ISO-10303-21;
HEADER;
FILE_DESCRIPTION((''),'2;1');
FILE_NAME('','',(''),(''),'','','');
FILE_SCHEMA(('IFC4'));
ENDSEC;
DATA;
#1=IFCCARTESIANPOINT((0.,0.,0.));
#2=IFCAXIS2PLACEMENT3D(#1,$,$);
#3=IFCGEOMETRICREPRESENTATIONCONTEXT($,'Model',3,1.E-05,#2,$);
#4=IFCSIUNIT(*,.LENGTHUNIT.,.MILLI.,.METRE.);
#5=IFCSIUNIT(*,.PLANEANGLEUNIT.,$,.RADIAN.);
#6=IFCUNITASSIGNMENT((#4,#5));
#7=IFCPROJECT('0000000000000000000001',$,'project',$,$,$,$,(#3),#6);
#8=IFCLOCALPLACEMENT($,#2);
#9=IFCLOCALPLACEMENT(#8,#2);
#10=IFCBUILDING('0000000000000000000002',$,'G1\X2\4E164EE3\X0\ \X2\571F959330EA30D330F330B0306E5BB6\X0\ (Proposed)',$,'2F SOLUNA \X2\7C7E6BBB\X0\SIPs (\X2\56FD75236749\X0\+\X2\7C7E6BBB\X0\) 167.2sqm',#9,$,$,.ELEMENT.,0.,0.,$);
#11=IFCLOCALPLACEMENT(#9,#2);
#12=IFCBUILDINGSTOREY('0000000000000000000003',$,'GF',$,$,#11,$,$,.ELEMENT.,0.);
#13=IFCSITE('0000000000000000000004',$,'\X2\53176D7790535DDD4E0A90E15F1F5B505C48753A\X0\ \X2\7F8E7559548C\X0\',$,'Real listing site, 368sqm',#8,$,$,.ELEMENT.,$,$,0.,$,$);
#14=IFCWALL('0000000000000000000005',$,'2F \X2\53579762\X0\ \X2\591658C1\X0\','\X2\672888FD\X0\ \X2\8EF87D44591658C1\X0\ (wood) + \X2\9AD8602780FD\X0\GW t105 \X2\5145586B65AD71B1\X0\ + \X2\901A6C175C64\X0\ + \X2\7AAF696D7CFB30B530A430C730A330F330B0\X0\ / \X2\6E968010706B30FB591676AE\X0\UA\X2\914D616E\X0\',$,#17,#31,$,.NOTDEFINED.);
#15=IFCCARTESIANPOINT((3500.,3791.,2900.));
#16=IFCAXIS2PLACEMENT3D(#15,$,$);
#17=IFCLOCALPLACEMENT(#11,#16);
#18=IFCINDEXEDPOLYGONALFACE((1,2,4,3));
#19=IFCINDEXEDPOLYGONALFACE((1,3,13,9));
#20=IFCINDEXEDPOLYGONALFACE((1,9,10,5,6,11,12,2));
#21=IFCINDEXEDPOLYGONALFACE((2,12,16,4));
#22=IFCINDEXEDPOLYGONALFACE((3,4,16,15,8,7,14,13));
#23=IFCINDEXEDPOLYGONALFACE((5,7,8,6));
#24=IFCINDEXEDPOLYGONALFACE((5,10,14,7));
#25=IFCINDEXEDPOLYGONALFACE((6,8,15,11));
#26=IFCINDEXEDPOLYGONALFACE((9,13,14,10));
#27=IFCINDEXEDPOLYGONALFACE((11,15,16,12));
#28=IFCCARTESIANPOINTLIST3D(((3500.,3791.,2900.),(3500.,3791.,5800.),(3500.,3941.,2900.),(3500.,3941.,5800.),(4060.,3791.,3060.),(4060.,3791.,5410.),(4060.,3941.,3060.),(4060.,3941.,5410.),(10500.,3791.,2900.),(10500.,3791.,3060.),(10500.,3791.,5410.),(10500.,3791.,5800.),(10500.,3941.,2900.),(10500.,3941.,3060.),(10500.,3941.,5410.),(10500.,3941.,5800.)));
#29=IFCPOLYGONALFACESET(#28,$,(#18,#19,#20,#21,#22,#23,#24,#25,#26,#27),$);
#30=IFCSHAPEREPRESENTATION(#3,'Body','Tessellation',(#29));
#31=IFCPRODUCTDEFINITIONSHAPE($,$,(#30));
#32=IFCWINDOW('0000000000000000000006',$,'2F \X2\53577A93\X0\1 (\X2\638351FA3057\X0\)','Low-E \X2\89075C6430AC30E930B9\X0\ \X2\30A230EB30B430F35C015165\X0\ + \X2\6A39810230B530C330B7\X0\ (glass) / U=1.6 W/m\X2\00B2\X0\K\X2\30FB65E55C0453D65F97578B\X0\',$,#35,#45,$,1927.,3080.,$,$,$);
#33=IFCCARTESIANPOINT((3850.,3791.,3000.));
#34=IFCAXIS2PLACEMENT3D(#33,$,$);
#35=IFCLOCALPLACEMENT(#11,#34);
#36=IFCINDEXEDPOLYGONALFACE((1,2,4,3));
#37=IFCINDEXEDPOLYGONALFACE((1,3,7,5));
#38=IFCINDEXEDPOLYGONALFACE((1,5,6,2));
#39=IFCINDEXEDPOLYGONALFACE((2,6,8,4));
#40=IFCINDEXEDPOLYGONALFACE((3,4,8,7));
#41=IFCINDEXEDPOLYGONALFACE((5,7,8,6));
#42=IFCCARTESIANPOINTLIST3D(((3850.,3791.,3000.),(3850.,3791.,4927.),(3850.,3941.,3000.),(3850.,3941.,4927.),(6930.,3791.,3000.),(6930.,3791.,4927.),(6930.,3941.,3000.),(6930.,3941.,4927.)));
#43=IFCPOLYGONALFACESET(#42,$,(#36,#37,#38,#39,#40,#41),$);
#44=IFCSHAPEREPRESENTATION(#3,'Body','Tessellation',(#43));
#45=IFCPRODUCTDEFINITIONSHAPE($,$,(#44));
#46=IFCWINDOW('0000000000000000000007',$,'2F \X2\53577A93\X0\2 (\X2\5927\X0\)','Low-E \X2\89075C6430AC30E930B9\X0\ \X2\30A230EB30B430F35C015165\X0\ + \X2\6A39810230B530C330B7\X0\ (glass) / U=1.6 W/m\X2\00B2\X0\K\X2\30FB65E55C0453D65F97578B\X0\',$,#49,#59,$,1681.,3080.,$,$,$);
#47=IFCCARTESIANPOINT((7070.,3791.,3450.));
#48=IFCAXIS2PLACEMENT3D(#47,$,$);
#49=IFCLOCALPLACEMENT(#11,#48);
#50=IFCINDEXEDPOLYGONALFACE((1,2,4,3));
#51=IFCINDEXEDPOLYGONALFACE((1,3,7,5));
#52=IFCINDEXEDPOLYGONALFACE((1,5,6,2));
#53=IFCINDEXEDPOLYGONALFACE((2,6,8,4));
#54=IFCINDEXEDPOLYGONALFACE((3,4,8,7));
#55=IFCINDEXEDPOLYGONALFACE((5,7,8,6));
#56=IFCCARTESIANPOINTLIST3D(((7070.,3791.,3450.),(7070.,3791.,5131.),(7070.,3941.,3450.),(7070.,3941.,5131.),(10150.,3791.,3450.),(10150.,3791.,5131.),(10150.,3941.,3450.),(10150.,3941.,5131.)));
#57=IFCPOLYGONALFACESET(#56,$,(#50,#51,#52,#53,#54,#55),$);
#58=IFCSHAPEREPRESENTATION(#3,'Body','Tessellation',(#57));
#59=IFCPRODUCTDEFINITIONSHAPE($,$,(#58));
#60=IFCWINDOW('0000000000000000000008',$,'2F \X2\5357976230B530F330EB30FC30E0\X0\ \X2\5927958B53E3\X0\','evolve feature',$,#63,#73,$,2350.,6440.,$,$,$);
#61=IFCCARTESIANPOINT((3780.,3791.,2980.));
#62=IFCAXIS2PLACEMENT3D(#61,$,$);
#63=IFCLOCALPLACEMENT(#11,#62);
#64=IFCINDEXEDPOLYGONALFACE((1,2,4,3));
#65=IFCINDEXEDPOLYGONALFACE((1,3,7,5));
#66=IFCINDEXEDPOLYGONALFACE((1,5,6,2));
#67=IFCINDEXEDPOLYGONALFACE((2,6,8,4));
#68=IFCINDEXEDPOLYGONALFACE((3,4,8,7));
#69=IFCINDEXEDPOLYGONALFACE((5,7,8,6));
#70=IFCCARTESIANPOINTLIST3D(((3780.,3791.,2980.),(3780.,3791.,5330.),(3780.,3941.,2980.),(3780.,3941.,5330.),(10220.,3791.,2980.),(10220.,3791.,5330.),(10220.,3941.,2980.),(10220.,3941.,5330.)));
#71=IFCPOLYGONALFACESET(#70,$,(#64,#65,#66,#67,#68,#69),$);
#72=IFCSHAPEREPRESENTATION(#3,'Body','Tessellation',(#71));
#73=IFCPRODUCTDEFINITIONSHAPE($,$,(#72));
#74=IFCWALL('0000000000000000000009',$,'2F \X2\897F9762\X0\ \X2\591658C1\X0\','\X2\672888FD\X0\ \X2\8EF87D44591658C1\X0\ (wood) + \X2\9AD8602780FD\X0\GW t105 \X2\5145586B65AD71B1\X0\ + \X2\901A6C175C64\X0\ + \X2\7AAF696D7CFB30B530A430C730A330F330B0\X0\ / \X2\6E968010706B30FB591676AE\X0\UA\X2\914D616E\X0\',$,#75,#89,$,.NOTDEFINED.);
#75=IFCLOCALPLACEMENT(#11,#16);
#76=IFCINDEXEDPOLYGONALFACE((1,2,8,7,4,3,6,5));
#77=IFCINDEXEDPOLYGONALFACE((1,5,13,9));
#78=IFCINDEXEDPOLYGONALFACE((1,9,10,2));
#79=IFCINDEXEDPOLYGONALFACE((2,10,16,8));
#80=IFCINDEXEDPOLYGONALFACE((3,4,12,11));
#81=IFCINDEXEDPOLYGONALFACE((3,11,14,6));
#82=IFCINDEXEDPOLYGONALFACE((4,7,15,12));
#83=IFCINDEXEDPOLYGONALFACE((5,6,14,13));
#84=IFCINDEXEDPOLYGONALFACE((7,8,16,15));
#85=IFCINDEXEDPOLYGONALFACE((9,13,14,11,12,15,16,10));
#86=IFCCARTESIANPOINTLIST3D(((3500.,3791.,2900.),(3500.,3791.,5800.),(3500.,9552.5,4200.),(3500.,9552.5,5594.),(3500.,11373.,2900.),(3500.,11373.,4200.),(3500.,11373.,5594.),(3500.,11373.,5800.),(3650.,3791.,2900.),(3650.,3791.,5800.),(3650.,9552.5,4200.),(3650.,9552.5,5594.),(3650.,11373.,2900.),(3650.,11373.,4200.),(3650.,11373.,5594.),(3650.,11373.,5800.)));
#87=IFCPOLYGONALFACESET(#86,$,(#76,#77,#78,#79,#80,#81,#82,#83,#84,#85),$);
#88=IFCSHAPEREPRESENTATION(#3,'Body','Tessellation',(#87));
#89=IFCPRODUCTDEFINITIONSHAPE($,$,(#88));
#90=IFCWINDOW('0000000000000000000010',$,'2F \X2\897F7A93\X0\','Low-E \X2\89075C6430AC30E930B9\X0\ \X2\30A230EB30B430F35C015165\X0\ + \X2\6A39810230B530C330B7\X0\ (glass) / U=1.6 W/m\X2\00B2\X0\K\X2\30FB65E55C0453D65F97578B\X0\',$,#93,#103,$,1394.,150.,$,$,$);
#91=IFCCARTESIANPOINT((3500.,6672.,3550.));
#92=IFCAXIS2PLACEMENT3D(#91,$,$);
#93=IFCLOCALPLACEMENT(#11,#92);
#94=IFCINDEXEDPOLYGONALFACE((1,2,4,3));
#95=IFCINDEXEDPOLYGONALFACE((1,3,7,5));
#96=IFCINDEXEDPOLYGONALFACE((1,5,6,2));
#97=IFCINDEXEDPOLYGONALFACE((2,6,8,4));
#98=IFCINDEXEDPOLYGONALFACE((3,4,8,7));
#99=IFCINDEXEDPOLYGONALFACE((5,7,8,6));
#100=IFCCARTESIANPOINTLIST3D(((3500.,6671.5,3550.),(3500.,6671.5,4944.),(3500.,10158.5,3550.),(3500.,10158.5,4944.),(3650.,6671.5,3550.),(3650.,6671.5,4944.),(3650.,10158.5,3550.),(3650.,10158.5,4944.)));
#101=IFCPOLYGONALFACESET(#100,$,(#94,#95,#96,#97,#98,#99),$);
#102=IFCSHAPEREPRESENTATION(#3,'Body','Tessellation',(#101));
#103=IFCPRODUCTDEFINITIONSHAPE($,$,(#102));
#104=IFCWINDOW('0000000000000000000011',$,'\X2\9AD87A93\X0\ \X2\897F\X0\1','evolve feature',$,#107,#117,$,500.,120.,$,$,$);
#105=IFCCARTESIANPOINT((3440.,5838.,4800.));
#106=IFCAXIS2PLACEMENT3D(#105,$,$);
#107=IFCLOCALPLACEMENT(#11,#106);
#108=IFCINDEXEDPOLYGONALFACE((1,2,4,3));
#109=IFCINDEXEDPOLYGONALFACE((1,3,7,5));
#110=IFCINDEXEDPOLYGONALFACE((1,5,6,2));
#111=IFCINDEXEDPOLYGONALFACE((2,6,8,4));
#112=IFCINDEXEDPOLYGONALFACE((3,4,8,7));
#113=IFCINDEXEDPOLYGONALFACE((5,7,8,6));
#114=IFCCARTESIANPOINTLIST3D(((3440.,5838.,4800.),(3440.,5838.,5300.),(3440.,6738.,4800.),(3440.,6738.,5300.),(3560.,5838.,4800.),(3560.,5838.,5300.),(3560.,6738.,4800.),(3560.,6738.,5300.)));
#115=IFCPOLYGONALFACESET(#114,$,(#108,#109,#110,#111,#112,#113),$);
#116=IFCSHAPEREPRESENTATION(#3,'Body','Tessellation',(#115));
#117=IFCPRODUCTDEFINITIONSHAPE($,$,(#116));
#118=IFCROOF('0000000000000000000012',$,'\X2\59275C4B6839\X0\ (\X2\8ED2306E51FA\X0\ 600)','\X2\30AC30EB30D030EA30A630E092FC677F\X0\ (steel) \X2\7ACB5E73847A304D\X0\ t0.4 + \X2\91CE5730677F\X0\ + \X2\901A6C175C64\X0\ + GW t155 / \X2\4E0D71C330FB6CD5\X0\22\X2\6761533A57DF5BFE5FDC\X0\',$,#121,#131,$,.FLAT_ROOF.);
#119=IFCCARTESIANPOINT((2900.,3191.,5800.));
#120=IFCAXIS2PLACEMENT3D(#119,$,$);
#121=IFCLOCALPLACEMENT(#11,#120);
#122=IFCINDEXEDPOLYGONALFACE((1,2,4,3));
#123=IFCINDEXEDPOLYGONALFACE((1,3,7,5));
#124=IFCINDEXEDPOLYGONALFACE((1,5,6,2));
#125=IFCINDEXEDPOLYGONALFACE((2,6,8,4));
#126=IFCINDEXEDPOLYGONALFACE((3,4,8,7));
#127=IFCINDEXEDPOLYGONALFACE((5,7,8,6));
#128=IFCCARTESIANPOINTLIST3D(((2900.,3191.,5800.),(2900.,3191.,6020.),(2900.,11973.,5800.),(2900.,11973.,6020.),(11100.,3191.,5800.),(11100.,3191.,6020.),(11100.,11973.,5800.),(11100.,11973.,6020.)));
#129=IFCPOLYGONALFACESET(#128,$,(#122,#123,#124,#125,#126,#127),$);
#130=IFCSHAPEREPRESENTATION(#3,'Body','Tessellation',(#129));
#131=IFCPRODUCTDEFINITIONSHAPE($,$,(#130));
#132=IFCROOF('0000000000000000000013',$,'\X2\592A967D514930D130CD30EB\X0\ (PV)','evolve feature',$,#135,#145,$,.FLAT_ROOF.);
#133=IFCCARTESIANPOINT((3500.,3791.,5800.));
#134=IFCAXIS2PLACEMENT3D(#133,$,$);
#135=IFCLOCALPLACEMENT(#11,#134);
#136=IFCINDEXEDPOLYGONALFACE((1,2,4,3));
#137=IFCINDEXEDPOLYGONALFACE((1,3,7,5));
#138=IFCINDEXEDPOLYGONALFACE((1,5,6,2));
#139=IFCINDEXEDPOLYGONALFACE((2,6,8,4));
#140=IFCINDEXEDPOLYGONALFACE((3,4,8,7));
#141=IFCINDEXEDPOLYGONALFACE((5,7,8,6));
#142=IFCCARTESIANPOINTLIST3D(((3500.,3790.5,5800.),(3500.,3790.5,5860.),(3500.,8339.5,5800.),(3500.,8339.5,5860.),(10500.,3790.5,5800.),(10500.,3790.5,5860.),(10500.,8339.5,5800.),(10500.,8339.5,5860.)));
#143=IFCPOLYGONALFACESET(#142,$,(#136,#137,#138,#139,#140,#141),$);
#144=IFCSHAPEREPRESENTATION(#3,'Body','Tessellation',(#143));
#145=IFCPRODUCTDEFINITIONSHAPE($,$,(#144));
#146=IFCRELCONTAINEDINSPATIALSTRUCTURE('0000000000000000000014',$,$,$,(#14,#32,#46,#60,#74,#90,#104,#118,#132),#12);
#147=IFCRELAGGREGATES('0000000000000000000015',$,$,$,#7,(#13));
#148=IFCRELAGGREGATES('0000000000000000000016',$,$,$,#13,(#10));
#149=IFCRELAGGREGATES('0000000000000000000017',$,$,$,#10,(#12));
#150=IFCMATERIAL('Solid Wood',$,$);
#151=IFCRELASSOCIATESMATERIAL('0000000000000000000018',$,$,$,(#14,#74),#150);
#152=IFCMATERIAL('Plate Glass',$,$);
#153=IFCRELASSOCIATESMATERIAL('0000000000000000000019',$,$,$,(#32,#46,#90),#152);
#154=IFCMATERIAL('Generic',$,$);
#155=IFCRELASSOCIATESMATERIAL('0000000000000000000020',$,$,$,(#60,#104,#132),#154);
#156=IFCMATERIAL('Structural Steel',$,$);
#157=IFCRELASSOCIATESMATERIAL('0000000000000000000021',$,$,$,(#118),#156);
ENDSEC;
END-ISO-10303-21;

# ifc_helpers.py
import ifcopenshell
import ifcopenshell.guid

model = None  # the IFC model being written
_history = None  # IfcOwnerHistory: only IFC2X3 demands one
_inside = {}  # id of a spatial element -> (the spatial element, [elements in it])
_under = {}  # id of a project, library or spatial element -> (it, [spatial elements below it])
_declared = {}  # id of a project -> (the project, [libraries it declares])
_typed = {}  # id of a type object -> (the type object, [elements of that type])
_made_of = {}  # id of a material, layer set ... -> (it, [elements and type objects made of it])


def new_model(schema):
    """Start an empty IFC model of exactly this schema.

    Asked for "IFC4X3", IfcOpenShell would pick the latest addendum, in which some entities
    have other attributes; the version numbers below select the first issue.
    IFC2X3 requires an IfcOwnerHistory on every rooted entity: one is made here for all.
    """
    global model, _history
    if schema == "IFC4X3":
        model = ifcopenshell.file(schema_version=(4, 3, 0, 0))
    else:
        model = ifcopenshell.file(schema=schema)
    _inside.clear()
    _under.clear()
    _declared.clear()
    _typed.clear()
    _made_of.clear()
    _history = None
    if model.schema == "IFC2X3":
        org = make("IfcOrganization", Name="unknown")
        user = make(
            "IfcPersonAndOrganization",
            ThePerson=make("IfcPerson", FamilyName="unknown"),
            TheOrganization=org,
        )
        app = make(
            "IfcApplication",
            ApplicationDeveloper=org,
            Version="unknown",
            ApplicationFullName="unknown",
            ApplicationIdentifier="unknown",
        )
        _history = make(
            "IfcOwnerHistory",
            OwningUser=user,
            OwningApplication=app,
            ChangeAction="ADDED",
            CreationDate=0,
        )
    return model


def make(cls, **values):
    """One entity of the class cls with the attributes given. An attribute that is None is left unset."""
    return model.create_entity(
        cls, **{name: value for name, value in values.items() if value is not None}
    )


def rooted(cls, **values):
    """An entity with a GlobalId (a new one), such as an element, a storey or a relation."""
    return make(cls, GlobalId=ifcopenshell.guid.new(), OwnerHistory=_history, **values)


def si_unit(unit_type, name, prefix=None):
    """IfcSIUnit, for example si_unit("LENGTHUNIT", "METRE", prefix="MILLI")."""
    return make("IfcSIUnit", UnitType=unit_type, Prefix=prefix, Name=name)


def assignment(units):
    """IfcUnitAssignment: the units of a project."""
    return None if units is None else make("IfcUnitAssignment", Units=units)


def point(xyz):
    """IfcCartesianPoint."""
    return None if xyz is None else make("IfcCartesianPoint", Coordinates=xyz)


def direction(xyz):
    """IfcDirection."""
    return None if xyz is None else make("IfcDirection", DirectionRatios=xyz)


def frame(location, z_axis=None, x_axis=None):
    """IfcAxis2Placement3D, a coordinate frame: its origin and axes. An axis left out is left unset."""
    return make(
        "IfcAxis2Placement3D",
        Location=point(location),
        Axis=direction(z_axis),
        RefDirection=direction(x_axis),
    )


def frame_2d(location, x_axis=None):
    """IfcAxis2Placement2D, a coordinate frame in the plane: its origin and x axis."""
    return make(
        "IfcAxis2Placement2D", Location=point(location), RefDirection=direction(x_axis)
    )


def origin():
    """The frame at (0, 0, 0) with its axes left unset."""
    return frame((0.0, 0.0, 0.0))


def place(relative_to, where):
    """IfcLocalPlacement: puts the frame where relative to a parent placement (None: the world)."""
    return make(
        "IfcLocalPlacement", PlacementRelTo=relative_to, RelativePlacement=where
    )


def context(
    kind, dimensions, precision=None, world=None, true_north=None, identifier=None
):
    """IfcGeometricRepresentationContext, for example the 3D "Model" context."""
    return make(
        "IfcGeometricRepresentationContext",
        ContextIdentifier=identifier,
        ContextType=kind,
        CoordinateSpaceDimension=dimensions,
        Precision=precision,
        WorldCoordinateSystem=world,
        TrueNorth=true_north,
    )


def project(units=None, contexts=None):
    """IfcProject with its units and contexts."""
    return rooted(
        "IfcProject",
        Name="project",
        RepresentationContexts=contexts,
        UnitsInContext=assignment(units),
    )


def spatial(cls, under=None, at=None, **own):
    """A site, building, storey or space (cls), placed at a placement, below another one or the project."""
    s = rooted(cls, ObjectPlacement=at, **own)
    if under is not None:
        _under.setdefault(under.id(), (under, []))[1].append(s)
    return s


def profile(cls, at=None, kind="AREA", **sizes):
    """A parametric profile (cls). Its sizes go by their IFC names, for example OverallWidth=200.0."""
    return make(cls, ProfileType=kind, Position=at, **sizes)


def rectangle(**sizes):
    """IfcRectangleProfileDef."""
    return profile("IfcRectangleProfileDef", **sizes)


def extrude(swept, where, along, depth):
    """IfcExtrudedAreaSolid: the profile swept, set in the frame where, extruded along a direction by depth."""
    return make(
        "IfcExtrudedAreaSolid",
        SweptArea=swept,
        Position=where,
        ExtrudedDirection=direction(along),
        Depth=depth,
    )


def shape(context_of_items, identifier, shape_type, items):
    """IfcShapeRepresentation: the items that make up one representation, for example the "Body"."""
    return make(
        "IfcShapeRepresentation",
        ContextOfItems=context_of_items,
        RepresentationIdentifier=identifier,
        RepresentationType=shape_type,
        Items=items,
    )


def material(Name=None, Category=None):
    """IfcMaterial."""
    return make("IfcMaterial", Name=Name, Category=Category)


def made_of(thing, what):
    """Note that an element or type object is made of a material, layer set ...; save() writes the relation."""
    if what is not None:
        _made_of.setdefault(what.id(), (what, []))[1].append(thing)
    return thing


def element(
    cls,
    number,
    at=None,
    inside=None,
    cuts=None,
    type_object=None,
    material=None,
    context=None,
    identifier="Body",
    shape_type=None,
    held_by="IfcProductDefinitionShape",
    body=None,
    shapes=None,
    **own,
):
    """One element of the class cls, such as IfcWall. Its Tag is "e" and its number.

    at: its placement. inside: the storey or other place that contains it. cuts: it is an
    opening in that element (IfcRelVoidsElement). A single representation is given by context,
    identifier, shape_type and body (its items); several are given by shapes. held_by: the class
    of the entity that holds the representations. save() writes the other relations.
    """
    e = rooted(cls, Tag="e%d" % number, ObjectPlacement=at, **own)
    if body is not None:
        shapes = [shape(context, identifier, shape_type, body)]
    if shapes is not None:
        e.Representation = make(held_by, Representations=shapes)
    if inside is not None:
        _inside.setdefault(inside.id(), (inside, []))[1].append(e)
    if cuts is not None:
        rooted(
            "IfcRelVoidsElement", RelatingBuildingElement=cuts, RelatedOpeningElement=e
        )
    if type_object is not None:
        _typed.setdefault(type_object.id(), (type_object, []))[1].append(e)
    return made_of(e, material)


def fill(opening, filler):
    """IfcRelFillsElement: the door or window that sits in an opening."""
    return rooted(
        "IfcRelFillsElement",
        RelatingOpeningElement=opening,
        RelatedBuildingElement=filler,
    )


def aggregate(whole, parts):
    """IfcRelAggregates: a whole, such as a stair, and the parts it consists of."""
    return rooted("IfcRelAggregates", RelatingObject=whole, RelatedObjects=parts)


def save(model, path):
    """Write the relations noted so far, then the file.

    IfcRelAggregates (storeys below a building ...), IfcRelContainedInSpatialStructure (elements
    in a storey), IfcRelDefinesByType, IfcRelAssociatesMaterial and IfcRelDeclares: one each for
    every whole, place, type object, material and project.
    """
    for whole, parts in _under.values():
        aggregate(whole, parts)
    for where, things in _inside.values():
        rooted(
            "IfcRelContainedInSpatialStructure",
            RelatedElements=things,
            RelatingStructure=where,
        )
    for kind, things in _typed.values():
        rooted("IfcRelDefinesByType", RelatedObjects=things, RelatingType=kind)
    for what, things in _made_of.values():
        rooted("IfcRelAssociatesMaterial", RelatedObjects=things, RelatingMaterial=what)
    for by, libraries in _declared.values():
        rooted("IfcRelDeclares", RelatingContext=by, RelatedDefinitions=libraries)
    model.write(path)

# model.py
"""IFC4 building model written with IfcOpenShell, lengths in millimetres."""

from ifc_helpers import new_model, si_unit, frame, frame_2d, origin, place, context, project, spatial, rectangle, extrude, material, element, fill, save


model = new_model("IFC4")

# Units and contexts
model_context = context("Model", 3, precision=1e-05, world=origin())
ifc_project = project(units=[si_unit("LENGTHUNIT", "METRE", prefix="MILLI"), si_unit("PLANEANGLEUNIT", "RADIAN")], contexts=[model_context])

# Site, building, storey
site_placement = place(None, origin())
site = spatial("IfcSite", under=ifc_project, at=site_placement, Name="北海道川上郡弟子屈町 美留和", ObjectType="Real listing site, 368sqm", CompositionType="ELEMENT", RefElevation=0.0)
building_placement = place(site_placement, origin())
building = spatial("IfcBuilding", under=site, at=building_placement, Name="G1世代 土間リビングの家 (Proposed)", ObjectType="2F SOLUNA 籾殻SIPs (国産杉+籾殻) 167.2sqm", CompositionType="ELEMENT", ElevationOfRefHeight=0.0, ElevationOfTerrain=0.0)
storey_placement = place(building_placement, origin())
storey = spatial("IfcBuildingStorey", under=building, at=storey_placement, Name="GF", CompositionType="ELEMENT", Elevation=0.0)

# Shared definitions
ifc_material_1 = material(Name="Solid Wood")
ifc_material_2 = material(Name="Generic")

# Shared definitions
ifc_material_3 = material(Name="Plate Glass")

# Walls, openings, windows
wall_1_placement = place(storey_placement, frame((3500.0, 3791.0, 2900.0)))
wall_1 = element("IfcWall", 1, at=wall_1_placement, inside=storey, material=ifc_material_1, Name="2F 南面 外壁", Description="木製 軸組外壁 (wood) + 高性能GW t105 充填断熱 + 通気層 + 窯業系サイディング / 準耐火・外皮UA配慮", PredefinedType="NOTDEFINED", context=model_context, shape_type="SweptSolid", body=[
    extrude(rectangle(XDim=7000.0, YDim=150.0, at=frame_2d((3500.0, 75.0))), frame((3500.0, 3791.0, 2900.0)), (0.0, 0.0, 1.0), 2900.0),
])
opening_1_placement = place(storey_placement, frame((3850.0, 3791.0, 3000.0)))
opening_1 = element("IfcOpeningElement", 2, at=opening_1_placement, cuts=wall_1, PredefinedType="NOTDEFINED", context=model_context, shape_type="SweptSolid", body=[
    extrude(rectangle(XDim=3080.0, YDim=150.0, at=frame_2d((1540.0, 75.0))), frame((3850.0, 3791.0, 3000.0)), (0.0, 0.0, 1.0), 1927.0),
])
opening_2_placement = place(storey_placement, frame((7070.0, 3791.0, 3450.0)))
opening_2 = element("IfcOpeningElement", 3, at=opening_2_placement, cuts=wall_1, PredefinedType="NOTDEFINED", context=model_context, shape_type="SweptSolid", body=[
    extrude(rectangle(XDim=3080.0, YDim=150.0, at=frame_2d((1540.0, 75.0))), frame((7070.0, 3791.0, 3450.0)), (0.0, 0.0, 1.0), 1681.0),
])
opening_3_placement = place(storey_placement, frame((3780.0, 3791.0, 2980.0)))
opening_3 = element("IfcOpeningElement", 4, at=opening_3_placement, cuts=wall_1, PredefinedType="NOTDEFINED", context=model_context, shape_type="SweptSolid", body=[
    extrude(rectangle(XDim=6440.0, YDim=150.0, at=frame_2d((3220.0, 75.0))), frame((3780.0, 3791.0, 2980.0)), (0.0, 0.0, 1.0), 2350.0),
])
window_1_placement = place(storey_placement, frame((3850.0, 3791.0, 3000.0)))
window_1 = element("IfcWindow", 5, at=window_1_placement, inside=storey, material=ifc_material_3, Name="2F 南窓1 (掃出し)", Description="Low-E 複層ガラス アルゴン封入 + 樹脂サッシ (glass) / U=1.6 W/m²K・日射取得型", OverallHeight=1927.0, OverallWidth=3080.0, context=model_context, shape_type="SweptSolid", body=[
    extrude(rectangle(XDim=3080.0, YDim=150.0, at=frame_2d((1540.0, 75.0))), frame((3850.0, 3791.0, 3000.0)), (0.0, 0.0, 1.0), 1927.0),
])
fill(opening_1, window_1)
window_2_placement = place(storey_placement, frame((7070.0, 3791.0, 3450.0)))
window_2 = element("IfcWindow", 6, at=window_2_placement, inside=storey, material=ifc_material_3, Name="2F 南窓2 (大)", Description="Low-E 複層ガラス アルゴン封入 + 樹脂サッシ (glass) / U=1.6 W/m²K・日射取得型", OverallHeight=1681.0, OverallWidth=3080.0, context=model_context, shape_type="SweptSolid", body=[
    extrude(rectangle(XDim=3080.0, YDim=150.0, at=frame_2d((1540.0, 75.0))), frame((7070.0, 3791.0, 3450.0)), (0.0, 0.0, 1.0), 1681.0),
])
fill(opening_2, window_2)
window_3_placement = place(storey_placement, frame((3780.0, 3791.0, 2980.0)))
window_3 = element("IfcWindow", 7, at=window_3_placement, inside=storey, material=ifc_material_2, Name="2F 南面サンルーム 大開口", Description="evolve feature", OverallHeight=2350.0, OverallWidth=6440.0, context=model_context, shape_type="SweptSolid", body=[
    extrude(rectangle(XDim=6440.0, YDim=150.0, at=frame_2d((3220.0, 75.0))), frame((3780.0, 3791.0, 2980.0)), (0.0, 0.0, 1.0), 2350.0),
])
fill(opening_3, window_3)
wall_2_placement = place(storey_placement, frame((3500.0, 3791.0, 2900.0)))
wall_2 = element("IfcWall", 8, at=wall_2_placement, inside=storey, material=ifc_material_1, Name="2F 西面 外壁", Description="木製 軸組外壁 (wood) + 高性能GW t105 充填断熱 + 通気層 + 窯業系サイディング / 準耐火・外皮UA配慮", PredefinedType="NOTDEFINED", context=model_context, shape_type="SweptSolid", body=[
    extrude(rectangle(XDim=150.0, YDim=7582.0, at=frame_2d((75.0, 3791.0))), frame((3500.0, 3791.0, 2900.0)), (0.0, 0.0, 1.0), 2900.0),
])
opening_4_placement = place(storey_placement, frame((3500.0, 6672.0, 3550.0)))
opening_4 = element("IfcOpeningElement", 9, at=opening_4_placement, cuts=wall_2, PredefinedType="NOTDEFINED", context=model_context, shape_type="SweptSolid", body=[
    extrude(rectangle(XDim=150.0, YDim=3487.0, at=frame_2d((75.0, 1743.0))), frame((3500.0, 6672.0, 3550.0)), (0.0, 0.0, 1.0), 1394.0),
])
opening_5_placement = place(storey_placement, frame((3440.0, 5838.0, 4800.0)))
opening_5 = element("IfcOpeningElement", 10, at=opening_5_placement, cuts=wall_2, PredefinedType="NOTDEFINED", context=model_context, shape_type="SweptSolid", body=[
    extrude(rectangle(XDim=120.0, YDim=900.0, at=frame_2d((60.0, 450.0))), frame((3440.0, 5838.0, 4800.0)), (0.0, 0.0, 1.0), 500.0),
])
window_4_placement = place(storey_placement, frame((3500.0, 6672.0, 3550.0)))
window_4 = element("IfcWindow", 11, at=window_4_placement, inside=storey, material=ifc_material_3, Name="2F 西窓", Description="Low-E 複層ガラス アルゴン封入 + 樹脂サッシ (glass) / U=1.6 W/m²K・日射取得型", OverallHeight=1394.0, OverallWidth=150.0, context=model_context, shape_type="SweptSolid", body=[
    extrude(rectangle(XDim=150.0, YDim=3487.0, at=frame_2d((75.0, 1743.0))), frame((3500.0, 6672.0, 3550.0)), (0.0, 0.0, 1.0), 1394.0),
])
fill(opening_4, window_4)
window_5_placement = place(storey_placement, frame((3440.0, 5838.0, 4800.0)))
window_5 = element("IfcWindow", 12, at=window_5_placement, inside=storey, material=ifc_material_2, Name="高窓 西1", Description="evolve feature", OverallHeight=500.0, OverallWidth=120.0, context=model_context, shape_type="SweptSolid", body=[
    extrude(rectangle(XDim=120.0, YDim=900.0, at=frame_2d((60.0, 450.0))), frame((3440.0, 5838.0, 4800.0)), (0.0, 0.0, 1.0), 500.0),
])
fill(opening_5, window_5)

# Roofs
ifc_material_4 = material(Name="Structural Steel")
roof_1_placement = place(storey_placement, frame((2900.0, 3191.0, 5800.0)))
element("IfcRoof", 13, at=roof_1_placement, inside=storey, material=ifc_material_4, Name="大屋根 (軒の出 600)", Description="ガルバリウム鋼板 (steel) 立平葺き t0.4 + 野地板 + 通気層 + GW t155 / 不燃・法22条区域対応", PredefinedType="FLAT_ROOF", context=model_context, shape_type="SweptSolid", body=[
    extrude(rectangle(XDim=8200.0, YDim=8782.0, at=frame_2d((4100.0, 4391.0))), frame((2900.0, 3191.0, 5800.0)), (0.0, 0.0, 1.0), 220.0),
])
roof_2_placement = place(storey_placement, frame((3500.0, 3791.0, 5800.0)))
element("IfcRoof", 14, at=roof_2_placement, inside=storey, material=ifc_material_2, Name="太陽光パネル (PV)", Description="evolve feature", PredefinedType="FLAT_ROOF", context=model_context, shape_type="SweptSolid", body=[
    extrude(rectangle(XDim=7000.0, YDim=4549.0, at=frame_2d((3500.0, 2274.0))), frame((3500.0, 3791.0, 5800.0)), (0.0, 0.0, 1.0), 60.0),
])

save(model, "model.ifc")
